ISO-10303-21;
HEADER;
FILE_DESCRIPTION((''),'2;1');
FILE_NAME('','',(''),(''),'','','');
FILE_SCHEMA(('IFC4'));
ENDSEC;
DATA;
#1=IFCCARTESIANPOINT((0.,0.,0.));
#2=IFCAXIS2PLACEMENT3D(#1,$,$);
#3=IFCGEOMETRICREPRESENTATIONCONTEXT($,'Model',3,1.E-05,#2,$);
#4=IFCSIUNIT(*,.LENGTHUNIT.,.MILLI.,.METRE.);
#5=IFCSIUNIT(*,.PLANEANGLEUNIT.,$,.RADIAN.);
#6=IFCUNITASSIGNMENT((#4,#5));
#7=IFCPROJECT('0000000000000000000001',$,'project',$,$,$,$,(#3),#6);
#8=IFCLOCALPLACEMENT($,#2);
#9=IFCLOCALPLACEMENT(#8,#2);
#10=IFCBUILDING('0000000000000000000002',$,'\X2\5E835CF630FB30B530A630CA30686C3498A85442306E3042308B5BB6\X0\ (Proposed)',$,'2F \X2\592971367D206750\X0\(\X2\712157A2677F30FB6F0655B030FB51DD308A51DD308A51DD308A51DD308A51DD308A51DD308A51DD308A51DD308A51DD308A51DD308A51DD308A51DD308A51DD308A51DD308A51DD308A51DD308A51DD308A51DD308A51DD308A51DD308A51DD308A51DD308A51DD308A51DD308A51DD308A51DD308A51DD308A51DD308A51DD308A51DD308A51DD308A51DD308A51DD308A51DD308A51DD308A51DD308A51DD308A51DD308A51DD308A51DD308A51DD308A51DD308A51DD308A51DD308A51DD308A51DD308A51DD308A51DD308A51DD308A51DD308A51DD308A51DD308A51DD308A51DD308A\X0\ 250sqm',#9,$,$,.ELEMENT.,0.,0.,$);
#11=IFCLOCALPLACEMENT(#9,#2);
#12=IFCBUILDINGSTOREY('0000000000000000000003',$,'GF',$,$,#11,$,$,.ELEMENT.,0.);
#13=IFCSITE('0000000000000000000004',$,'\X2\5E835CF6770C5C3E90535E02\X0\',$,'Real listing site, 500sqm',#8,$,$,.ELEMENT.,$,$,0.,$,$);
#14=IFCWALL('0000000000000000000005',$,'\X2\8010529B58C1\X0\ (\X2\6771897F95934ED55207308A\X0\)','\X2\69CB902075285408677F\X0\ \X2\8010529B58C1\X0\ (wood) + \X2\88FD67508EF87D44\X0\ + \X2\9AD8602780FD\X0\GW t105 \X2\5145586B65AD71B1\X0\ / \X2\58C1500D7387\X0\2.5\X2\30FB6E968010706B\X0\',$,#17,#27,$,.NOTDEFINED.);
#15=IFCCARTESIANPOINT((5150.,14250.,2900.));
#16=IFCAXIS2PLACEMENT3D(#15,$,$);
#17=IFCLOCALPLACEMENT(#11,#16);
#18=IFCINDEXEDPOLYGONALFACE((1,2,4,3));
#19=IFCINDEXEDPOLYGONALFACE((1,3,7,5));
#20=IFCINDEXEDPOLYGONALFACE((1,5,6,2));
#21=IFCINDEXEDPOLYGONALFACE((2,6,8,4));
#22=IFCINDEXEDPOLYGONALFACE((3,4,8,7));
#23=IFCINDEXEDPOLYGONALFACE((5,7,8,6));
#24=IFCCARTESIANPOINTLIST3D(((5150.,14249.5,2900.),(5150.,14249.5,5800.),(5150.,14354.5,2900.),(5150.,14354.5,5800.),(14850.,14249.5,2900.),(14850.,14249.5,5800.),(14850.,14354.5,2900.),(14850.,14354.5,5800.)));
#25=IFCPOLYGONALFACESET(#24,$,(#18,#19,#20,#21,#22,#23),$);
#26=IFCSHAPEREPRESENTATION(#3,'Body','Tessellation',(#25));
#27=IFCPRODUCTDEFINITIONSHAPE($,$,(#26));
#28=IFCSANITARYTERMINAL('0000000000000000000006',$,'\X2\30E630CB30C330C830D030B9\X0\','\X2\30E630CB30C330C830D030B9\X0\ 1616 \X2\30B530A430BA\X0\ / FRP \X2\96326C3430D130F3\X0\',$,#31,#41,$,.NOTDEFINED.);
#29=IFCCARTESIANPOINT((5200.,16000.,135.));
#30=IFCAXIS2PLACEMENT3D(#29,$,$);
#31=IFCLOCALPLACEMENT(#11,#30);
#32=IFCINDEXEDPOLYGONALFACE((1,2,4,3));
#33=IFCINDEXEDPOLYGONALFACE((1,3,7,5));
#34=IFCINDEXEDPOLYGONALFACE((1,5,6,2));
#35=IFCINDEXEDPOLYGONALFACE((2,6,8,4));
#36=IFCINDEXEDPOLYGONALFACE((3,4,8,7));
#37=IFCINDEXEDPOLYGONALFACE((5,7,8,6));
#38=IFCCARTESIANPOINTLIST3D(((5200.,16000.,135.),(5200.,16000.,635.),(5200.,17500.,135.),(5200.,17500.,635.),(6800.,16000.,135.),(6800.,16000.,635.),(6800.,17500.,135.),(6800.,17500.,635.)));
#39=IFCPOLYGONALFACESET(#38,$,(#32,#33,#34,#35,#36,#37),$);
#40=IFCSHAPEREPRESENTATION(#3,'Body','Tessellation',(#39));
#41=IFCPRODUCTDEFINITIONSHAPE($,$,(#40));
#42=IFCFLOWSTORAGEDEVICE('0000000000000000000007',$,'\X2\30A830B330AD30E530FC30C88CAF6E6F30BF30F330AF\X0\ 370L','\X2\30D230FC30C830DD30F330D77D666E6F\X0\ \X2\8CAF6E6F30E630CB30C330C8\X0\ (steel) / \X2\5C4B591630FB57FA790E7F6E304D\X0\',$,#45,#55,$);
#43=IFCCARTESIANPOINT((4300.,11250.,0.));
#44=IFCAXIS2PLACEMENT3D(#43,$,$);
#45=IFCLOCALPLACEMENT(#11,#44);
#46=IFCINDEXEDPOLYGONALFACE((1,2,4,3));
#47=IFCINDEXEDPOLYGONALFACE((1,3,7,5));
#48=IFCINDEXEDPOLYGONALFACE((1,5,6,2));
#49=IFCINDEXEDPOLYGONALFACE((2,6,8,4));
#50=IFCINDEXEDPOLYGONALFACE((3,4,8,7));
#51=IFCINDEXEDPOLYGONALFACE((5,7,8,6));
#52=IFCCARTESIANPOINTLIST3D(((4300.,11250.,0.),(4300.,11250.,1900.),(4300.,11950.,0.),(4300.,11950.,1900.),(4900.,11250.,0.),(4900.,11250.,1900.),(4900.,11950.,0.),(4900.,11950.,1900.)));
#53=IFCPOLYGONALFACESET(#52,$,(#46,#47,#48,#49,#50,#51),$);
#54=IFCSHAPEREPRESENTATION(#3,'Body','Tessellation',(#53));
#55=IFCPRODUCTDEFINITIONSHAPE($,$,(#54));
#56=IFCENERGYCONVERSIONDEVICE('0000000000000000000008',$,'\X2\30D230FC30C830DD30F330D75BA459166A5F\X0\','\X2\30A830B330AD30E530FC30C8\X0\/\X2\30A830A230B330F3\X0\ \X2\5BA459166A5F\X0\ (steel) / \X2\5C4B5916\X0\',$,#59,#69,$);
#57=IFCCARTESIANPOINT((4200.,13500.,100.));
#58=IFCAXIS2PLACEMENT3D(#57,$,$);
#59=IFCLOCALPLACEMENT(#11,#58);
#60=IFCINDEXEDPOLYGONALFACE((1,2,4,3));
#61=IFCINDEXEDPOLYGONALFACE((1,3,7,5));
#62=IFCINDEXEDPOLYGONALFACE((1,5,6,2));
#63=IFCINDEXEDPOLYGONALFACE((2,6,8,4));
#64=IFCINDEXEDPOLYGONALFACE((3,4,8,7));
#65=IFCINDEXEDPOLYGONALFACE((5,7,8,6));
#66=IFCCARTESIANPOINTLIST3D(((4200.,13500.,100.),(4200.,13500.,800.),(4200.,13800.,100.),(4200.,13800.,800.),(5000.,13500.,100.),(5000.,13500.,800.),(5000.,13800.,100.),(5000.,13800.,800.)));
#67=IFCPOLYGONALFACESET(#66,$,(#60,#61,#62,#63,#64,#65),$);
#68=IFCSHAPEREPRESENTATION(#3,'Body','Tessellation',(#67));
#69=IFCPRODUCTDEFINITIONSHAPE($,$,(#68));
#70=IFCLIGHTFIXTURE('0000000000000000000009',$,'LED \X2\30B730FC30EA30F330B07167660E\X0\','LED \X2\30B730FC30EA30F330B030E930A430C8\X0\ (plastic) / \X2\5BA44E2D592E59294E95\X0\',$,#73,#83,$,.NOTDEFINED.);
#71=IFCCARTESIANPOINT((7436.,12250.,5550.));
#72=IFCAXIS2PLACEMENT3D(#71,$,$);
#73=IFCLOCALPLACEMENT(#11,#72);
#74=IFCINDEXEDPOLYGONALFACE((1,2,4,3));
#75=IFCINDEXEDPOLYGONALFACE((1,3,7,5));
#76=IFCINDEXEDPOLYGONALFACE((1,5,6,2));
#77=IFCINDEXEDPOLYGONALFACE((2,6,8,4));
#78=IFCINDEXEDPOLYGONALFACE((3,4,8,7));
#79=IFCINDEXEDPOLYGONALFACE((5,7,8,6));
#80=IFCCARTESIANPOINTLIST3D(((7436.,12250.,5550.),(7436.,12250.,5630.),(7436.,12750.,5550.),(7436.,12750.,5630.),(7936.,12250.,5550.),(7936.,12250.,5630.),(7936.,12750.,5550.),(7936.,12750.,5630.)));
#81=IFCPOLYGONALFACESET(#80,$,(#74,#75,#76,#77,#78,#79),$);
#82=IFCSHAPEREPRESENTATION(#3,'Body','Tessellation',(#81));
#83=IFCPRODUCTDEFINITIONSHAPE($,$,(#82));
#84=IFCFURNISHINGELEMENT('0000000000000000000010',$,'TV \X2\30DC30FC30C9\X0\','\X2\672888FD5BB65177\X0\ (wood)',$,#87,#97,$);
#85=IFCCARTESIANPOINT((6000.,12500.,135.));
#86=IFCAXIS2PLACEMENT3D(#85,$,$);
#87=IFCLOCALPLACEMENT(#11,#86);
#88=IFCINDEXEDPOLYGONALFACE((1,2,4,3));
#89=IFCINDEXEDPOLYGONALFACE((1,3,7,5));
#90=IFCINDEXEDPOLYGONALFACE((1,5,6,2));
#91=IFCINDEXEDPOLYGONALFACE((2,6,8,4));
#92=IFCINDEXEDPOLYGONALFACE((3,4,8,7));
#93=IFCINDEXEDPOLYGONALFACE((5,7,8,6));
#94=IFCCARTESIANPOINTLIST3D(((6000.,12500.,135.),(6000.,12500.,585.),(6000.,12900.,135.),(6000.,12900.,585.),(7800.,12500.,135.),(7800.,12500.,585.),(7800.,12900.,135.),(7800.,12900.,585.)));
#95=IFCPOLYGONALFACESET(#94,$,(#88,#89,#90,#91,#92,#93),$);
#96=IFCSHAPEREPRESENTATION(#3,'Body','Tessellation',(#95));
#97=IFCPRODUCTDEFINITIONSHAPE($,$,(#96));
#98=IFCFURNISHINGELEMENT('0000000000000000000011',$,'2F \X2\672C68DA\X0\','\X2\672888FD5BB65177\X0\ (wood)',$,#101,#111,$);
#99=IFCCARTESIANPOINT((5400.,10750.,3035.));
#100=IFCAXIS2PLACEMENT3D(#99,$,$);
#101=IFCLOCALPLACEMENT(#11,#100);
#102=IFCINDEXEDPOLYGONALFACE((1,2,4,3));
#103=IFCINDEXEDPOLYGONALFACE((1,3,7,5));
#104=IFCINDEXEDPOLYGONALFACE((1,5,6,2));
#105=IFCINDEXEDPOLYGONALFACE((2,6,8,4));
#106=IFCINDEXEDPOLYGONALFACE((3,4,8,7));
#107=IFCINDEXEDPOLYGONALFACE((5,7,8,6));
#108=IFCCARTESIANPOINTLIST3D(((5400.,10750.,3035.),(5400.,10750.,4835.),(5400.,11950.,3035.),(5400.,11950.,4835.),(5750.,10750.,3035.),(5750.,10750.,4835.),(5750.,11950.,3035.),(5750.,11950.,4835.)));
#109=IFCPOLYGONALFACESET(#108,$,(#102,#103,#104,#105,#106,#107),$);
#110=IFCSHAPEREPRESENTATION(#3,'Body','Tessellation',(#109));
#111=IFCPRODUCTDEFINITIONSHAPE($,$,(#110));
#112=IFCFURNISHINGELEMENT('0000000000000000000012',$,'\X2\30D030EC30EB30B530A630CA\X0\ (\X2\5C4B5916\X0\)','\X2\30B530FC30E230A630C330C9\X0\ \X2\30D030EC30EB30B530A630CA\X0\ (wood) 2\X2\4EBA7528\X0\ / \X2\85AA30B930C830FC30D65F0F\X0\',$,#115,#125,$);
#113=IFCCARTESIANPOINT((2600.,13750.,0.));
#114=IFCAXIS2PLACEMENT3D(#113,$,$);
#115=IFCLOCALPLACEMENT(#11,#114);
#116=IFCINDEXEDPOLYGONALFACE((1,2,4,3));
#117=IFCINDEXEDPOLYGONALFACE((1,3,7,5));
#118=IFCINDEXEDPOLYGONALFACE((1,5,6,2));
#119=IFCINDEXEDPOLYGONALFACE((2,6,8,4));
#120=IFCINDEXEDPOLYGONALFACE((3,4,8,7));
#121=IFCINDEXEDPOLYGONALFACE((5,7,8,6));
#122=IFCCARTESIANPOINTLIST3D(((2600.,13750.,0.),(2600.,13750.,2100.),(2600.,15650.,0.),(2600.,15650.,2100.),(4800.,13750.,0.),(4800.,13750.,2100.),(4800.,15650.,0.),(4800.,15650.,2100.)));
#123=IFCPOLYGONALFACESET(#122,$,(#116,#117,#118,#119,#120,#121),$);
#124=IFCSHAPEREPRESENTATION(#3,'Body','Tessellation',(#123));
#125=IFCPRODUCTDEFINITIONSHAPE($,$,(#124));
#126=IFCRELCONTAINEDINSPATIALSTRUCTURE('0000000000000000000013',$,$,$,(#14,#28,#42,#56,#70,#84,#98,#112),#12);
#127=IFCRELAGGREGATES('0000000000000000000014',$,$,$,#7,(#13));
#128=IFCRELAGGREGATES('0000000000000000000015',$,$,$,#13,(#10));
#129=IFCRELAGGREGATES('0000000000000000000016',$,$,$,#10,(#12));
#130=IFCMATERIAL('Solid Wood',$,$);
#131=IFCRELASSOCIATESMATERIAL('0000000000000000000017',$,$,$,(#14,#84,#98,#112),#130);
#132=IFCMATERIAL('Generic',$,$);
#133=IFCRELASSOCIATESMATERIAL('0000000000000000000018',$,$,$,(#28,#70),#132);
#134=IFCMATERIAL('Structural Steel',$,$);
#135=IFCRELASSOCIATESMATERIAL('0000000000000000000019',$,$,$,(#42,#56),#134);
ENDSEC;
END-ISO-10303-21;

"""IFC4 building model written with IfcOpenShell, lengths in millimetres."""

from ifc_helpers import new_model, si_unit, frame, frame_2d, origin, place, context, project, spatial, rectangle, extrude, material, element, save


model = new_model("IFC4")

# Units and contexts
model_context = context("Model", 3, precision=1e-05, world=origin())
ifc_project = project(units=[si_unit("LENGTHUNIT", "METRE", prefix="MILLI"), si_unit("PLANEANGLEUNIT", "RADIAN")], contexts=[model_context])

# Site, building, storey
site_placement = place(None, origin())
site = spatial("IfcSite", under=ifc_project, at=site_placement, Name="広島県尾道市", ObjectType="Real listing site, 500sqm", CompositionType="ELEMENT", RefElevation=0.0)
building_placement = place(site_placement, origin())
building = spatial("IfcBuilding", under=site, at=building_placement, Name="広島・サウナと水風呂のある家 (Proposed)", ObjectType="2F 天然素材(無垢板・漆喰・凝り凝り凝り凝り凝り凝り凝り凝り凝り凝り凝り凝り凝り凝り凝り凝り凝り凝り凝り凝り凝り凝り凝り凝り凝り凝り凝り凝り凝り凝り凝り凝り凝り凝り凝り凝り凝り凝り凝り凝り凝り凝り凝り凝り凝り凝り凝り凝り凝り凝り凝り凝り凝り凝り 250sqm", CompositionType="ELEMENT", ElevationOfRefHeight=0.0, ElevationOfTerrain=0.0)
storey_placement = place(building_placement, origin())
storey = spatial("IfcBuildingStorey", under=building, at=storey_placement, Name="GF", CompositionType="ELEMENT", Elevation=0.0)

# Shared definitions
ifc_material_1 = material(Name="Solid Wood")

# Wall
wall_1_placement = place(storey_placement, frame((5150.0, 14250.0, 2900.0)))
element("IfcWall", 1, at=wall_1_placement, inside=storey, material=ifc_material_1, Name="耐力壁 (東西間仕切り)", Description="構造用合板 耐力壁 (wood) + 製材軸組 + 高性能GW t105 充填断熱 / 壁倍率2.5・準耐火", PredefinedType="NOTDEFINED", context=model_context, shape_type="SweptSolid", body=[
    extrude(rectangle(XDim=9700.0, YDim=105.0, at=frame_2d((4850.0, 52.0))), frame((5150.0, 14250.0, 2900.0)), (0.0, 0.0, 1.0), 2900.0),
])

# Sanitary terminal
ifc_material_2 = material(Name="Generic")
sanitary_terminal_placement = place(storey_placement, frame((5200.0, 16000.0, 135.0)))
element("IfcSanitaryTerminal", 2, at=sanitary_terminal_placement, inside=storey, material=ifc_material_2, Name="ユニットバス", Description="ユニットバス 1616 サイズ / FRP 防水パン", PredefinedType="NOTDEFINED", context=model_context, shape_type="SweptSolid", body=[
    extrude(rectangle(XDim=1600.0, YDim=1500.0, at=frame_2d((800.0, 750.0))), frame((5200.0, 16000.0, 135.0)), (0.0, 0.0, 1.0), 500.0),
])

# Flow storage device
ifc_material_3 = material(Name="Structural Steel")
flow_storage_device_placement = place(storey_placement, frame((4300.0, 11250.0, 0.0)))
element("IfcFlowStorageDevice", 3, at=flow_storage_device_placement, inside=storey, material=ifc_material_3, Name="エコキュート貯湯タンク 370L", Description="ヒートポンプ給湯 貯湯ユニット (steel) / 屋外・基礎置き", context=model_context, shape_type="SweptSolid", body=[
    extrude(rectangle(XDim=600.0, YDim=700.0, at=frame_2d((300.0, 350.0))), frame((4300.0, 11250.0, 0.0)), (0.0, 0.0, 1.0), 1900.0),
])

# Energy conversion device
energy_conversion_device_placement = place(storey_placement, frame((4200.0, 13500.0, 100.0)))
element("IfcEnergyConversionDevice", 4, at=energy_conversion_device_placement, inside=storey, material=ifc_material_3, Name="ヒートポンプ室外機", Description="エコキュート/エアコン 室外機 (steel) / 屋外", context=model_context, shape_type="SweptSolid", body=[
    extrude(rectangle(XDim=800.0, YDim=300.0, at=frame_2d((400.0, 150.0))), frame((4200.0, 13500.0, 100.0)), (0.0, 0.0, 1.0), 700.0),
])

# Light fixture
light_fixture_placement = place(storey_placement, frame((7436.0, 12250.0, 5550.0)))
element("IfcLightFixture", 5, at=light_fixture_placement, inside=storey, material=ifc_material_2, Name="LED シーリング照明", Description="LED シーリングライト (plastic) / 室中央天井", PredefinedType="NOTDEFINED", context=model_context, shape_type="SweptSolid", body=[
    extrude(rectangle(XDim=500.0, YDim=500.0, at=frame_2d((250.0, 250.0))), frame((7436.0, 12250.0, 5550.0)), (0.0, 0.0, 1.0), 80.0),
])

# Furnishing elements
furnishing_1_placement = place(storey_placement, frame((6000.0, 12500.0, 135.0)))
element("IfcFurnishingElement", 6, at=furnishing_1_placement, inside=storey, material=ifc_material_1, Name="TV ボード", Description="木製家具 (wood)", context=model_context, shape_type="SweptSolid", body=[
    extrude(rectangle(XDim=1800.0, YDim=400.0, at=frame_2d((900.0, 200.0))), frame((6000.0, 12500.0, 135.0)), (0.0, 0.0, 1.0), 450.0),
])
furnishing_2_placement = place(storey_placement, frame((5400.0, 10750.0, 3035.0)))
element("IfcFurnishingElement", 7, at=furnishing_2_placement, inside=storey, material=ifc_material_1, Name="2F 本棚", Description="木製家具 (wood)", context=model_context, shape_type="SweptSolid", body=[
    extrude(rectangle(XDim=350.0, YDim=1200.0, at=frame_2d((175.0, 600.0))), frame((5400.0, 10750.0, 3035.0)), (0.0, 0.0, 1.0), 1800.0),
])
furnishing_3_placement = place(storey_placement, frame((2600.0, 13750.0, 0.0)))
element("IfcFurnishingElement", 8, at=furnishing_3_placement, inside=storey, material=ifc_material_1, Name="バレルサウナ (屋外)", Description="サーモウッド バレルサウナ (wood) 2人用 / 薪ストーブ式", context=model_context, shape_type="SweptSolid", body=[
    extrude(rectangle(XDim=2200.0, YDim=1900.0, at=frame_2d((1100.0, 950.0))), frame((2600.0, 13750.0, 0.0)), (0.0, 0.0, 1.0), 2100.0),
])

save(model, "model.ifc")
